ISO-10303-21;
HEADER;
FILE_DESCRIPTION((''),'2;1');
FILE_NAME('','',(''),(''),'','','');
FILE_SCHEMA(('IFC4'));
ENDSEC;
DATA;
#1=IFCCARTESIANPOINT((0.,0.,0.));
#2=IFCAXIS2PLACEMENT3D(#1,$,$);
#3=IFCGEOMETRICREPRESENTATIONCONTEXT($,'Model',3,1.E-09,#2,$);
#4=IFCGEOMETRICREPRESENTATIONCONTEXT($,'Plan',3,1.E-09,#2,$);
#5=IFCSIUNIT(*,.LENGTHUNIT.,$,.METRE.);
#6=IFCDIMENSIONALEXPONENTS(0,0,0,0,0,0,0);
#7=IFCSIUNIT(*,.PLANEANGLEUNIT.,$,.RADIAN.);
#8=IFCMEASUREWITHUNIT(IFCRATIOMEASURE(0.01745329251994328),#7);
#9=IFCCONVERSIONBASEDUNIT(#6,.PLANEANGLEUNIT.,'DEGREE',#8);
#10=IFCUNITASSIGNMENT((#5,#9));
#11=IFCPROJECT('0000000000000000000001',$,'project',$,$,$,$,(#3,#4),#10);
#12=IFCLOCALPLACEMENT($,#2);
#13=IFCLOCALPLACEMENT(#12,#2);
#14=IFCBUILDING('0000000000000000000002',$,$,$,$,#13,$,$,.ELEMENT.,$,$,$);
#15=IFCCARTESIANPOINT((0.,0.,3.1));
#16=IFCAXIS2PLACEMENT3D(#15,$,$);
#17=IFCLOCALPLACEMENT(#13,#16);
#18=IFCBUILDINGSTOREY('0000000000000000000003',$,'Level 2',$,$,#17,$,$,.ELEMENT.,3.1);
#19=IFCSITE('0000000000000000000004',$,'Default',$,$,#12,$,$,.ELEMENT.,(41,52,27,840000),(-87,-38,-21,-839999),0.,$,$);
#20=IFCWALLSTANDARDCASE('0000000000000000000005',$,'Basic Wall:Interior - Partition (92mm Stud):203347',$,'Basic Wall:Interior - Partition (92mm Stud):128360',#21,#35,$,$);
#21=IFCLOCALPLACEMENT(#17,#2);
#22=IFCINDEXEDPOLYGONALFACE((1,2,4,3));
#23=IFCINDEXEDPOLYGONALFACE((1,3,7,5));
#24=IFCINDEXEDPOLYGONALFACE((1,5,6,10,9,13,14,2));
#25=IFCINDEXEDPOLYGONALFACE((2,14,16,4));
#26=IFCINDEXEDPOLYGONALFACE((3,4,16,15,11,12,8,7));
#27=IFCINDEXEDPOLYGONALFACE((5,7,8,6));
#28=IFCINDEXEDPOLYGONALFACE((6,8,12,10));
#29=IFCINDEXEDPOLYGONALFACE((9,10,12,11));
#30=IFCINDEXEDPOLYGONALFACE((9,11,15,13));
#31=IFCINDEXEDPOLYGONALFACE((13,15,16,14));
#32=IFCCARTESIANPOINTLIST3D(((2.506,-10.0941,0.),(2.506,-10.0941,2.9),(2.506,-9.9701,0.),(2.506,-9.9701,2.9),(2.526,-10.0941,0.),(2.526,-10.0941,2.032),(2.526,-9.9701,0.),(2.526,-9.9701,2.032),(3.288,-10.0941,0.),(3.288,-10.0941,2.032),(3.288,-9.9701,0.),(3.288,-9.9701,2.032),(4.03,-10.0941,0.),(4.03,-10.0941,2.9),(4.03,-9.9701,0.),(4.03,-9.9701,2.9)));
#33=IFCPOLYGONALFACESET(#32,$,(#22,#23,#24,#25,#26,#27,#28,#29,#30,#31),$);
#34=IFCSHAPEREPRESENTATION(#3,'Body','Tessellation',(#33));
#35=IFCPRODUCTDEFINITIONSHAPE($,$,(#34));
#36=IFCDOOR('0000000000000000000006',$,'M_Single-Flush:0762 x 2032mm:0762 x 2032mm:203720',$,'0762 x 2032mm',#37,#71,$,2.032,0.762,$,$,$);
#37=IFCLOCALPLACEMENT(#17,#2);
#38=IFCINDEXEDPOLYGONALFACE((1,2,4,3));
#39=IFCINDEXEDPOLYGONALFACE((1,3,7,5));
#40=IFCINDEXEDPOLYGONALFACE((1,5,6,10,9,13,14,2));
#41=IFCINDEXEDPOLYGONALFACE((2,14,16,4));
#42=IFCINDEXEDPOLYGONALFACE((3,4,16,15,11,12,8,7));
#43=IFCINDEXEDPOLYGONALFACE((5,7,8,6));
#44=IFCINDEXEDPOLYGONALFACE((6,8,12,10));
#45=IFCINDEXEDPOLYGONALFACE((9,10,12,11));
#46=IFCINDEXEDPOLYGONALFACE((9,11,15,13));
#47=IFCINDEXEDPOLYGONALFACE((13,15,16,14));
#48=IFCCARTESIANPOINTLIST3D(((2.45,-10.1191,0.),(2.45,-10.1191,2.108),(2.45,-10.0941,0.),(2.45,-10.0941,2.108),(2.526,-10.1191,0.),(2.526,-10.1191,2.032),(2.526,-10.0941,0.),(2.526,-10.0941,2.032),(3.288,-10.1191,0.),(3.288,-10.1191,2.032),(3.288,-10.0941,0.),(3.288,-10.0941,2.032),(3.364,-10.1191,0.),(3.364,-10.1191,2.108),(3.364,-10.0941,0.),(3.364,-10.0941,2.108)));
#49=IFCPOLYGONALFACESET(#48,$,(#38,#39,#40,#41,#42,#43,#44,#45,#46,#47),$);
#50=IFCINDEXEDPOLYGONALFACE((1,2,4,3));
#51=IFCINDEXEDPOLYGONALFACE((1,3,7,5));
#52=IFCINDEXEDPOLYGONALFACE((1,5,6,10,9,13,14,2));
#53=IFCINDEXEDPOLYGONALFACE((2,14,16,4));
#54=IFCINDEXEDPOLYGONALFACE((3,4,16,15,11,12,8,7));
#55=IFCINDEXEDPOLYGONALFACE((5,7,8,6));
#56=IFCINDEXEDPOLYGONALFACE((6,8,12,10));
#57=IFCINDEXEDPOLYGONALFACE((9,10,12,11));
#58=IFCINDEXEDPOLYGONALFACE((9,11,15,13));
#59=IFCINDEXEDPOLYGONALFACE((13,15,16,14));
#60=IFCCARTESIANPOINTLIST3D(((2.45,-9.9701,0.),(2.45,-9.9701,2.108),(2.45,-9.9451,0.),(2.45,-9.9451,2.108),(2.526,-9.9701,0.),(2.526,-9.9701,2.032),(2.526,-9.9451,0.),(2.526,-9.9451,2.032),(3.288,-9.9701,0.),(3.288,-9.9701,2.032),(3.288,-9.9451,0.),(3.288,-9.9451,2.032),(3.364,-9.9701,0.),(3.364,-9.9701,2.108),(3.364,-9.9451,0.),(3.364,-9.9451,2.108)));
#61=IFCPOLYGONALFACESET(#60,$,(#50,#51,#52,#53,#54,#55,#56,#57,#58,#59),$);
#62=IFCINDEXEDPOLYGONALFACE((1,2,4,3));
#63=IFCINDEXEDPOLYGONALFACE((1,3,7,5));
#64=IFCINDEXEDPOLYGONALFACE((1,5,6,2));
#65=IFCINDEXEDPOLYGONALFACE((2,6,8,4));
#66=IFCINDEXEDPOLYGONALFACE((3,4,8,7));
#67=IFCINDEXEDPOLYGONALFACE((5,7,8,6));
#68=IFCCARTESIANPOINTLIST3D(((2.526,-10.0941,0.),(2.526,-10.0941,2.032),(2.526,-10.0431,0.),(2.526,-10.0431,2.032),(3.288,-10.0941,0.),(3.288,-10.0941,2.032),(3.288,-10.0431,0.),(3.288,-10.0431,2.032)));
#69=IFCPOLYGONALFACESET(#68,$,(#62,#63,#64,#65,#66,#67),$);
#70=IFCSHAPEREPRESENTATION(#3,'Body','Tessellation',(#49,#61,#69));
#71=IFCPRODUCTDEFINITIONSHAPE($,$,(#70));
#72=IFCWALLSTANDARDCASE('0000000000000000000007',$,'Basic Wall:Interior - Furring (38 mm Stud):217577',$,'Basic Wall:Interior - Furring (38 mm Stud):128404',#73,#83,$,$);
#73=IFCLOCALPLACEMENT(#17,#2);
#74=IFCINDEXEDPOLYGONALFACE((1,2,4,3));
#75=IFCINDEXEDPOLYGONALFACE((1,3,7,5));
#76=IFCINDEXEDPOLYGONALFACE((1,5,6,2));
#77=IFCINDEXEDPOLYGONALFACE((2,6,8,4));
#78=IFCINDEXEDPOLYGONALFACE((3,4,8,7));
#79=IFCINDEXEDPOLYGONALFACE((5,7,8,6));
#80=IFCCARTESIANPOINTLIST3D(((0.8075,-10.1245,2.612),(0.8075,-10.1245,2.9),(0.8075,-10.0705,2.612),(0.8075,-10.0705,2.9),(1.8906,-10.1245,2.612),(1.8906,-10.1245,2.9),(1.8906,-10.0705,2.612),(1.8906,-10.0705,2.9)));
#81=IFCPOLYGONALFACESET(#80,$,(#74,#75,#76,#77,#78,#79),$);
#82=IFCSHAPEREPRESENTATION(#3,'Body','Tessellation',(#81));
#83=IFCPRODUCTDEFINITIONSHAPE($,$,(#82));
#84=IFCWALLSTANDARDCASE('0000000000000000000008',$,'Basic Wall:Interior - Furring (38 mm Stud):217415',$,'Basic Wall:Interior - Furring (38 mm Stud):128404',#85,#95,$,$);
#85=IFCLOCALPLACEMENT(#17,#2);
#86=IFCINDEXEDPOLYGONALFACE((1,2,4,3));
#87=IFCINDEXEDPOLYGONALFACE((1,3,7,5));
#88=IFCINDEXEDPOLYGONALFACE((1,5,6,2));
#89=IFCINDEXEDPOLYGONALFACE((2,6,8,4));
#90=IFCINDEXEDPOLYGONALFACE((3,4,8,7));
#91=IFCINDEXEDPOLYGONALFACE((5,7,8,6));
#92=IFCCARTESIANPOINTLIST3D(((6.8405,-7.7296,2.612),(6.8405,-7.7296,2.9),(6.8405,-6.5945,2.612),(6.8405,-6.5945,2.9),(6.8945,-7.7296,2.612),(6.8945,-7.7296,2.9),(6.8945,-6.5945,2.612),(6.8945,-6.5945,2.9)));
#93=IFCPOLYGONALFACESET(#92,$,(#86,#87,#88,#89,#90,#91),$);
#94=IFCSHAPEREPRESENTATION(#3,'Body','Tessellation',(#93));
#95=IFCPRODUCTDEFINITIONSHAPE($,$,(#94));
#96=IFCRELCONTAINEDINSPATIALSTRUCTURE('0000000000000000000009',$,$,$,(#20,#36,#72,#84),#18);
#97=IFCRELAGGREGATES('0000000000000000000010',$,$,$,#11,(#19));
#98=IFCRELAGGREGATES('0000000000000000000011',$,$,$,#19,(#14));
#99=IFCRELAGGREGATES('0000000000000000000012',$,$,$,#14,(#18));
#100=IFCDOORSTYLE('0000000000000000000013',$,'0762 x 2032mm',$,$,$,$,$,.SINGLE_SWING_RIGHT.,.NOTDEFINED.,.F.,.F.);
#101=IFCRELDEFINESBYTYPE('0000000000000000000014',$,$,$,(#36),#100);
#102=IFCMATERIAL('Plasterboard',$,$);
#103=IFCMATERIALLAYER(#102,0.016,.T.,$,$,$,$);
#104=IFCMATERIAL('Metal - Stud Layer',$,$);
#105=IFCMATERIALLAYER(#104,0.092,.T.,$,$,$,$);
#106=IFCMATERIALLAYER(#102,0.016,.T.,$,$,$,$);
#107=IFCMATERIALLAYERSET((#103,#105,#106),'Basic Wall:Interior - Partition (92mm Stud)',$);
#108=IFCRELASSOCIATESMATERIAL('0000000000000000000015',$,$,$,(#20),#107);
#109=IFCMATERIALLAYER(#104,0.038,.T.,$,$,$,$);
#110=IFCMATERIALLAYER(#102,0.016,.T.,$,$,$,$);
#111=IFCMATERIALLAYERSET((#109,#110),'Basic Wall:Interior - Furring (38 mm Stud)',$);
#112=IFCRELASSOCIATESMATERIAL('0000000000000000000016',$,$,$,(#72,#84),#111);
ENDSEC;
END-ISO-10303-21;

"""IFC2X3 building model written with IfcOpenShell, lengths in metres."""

from ifc_helpers import new_model, entity, si_unit, converted_unit, frame, frame_2d, origin, origin_2d_with_axis, place, context, project, spatial, polyline, rectangle, outline, extrude, source, transform, mapped, material, layer, layer_set, layer_usage, type_object, type_shapes, element, fill, save


model = new_model("IFC2X3")

# Units and contexts
model_context = context("Model", 3, precision=1e-09, world=origin())
plan_context = context("Plan", 3, precision=1e-09, world=origin())
ifc_project = project(units=[si_unit("LENGTHUNIT", "METRE"), converted_unit("PLANEANGLEUNIT", "DEGREE", entity("IfcRatioMeasure", 0.01745329251994328), si_unit("PLANEANGLEUNIT", "RADIAN"), dimensions=[0, 0, 0, 0, 0, 0, 0])], contexts=[model_context, plan_context])

# Site, building, storey
site_placement = place(None, origin())
site = spatial("IfcSite", under=ifc_project, at=site_placement, Name="Default", CompositionType="ELEMENT", RefLatitude=(41, 52, 27, 840000), RefLongitude=(-87, -38, -21, -839999), RefElevation=0.0)
building_placement = place(site_placement, origin())
building = spatial("IfcBuilding", under=site, at=building_placement, CompositionType="ELEMENT")
storey_placement = place(building_placement, frame((0.0, 0.0, 3.1)))
storey = spatial("IfcBuildingStorey", under=building, at=storey_placement, Name="Level 2", CompositionType="ELEMENT", Elevation=3.1)

# Shared definitions
ifc_material_1 = material(Name="Plasterboard")
ifc_layer_1 = layer(ifc_material_1, 0.016, ventilated=True)
ifc_material_2 = material(Name="Metal - Stud Layer")
ifc_layer_2 = layer(ifc_material_2, 0.092, ventilated=True)
ifc_layer_3 = layer(ifc_material_1, 0.016, ventilated=True)
ifc_layer_set_1 = layer_set([ifc_layer_1, ifc_layer_2, ifc_layer_3], Name="Basic Wall:Interior - Partition (92mm Stud)")
ifc_layer_usage_1 = layer_usage(ifc_layer_set_1, "AXIS2", "NEGATIVE", 0.062)
ifc_layer_4 = layer(ifc_material_2, 0.038, ventilated=True)
ifc_layer_5 = layer(ifc_material_1, 0.016, ventilated=True)
ifc_layer_set_2 = layer_set([ifc_layer_4, ifc_layer_5], Name="Basic Wall:Interior - Furring (38 mm Stud)")
ifc_layer_usage_2 = layer_usage(ifc_layer_set_2, "AXIS2", "NEGATIVE", 0.027)

# Shared definitions
door_style = type_object("IfcDoorStyle", Name="0762 x 2032mm", ConstructionType="NOTDEFINED", OperationType="SINGLE_SWING_RIGHT", ParameterTakesPrecedence=False, Sizeable=False)
shared_shape = source(origin(), model_context, "Body", "SweptSolid", [
    extrude(outline(polyline([(-0.457, -1.073), (0.457, -1.073), (0.457, 1.035), (0.381, 1.035), (0.381, -0.997), (-0.381, -0.997), (-0.381, 1.035), (-0.457, 1.035), (-0.457, -1.073)])), frame((0.381, 0.124, 1.035), z_axis=(0.0, 1.0, 0.0), x_axis=(1.0, 0.0, 0.0)), (0.0, 0.0, 1.0), 0.025),
    extrude(outline(polyline([(-1.073, -0.457), (1.035, -0.457), (1.035, -0.381), (-0.997, -0.381), (-0.997, 0.381), (1.035, 0.381), (1.035, 0.457), (-1.073, 0.457), (-1.073, -0.457)])), frame((0.381, -0.025, 1.035), z_axis=(0.0, 1.0, 0.0), x_axis=(0.0, 0.0, -1.0)), (0.0, 0.0, 1.0), 0.025),
    extrude(rectangle(XDim=0.051, YDim=0.762, at=origin_2d_with_axis()), frame((0.381, 0.0985, 0.0), z_axis=(0.0, 0.0, 1.0), x_axis=(0.0, 1.0, 0.0)), (0.0, 0.0, 1.0), 2.032),
])
type_shapes(door_style, [shared_shape])

# Wall, opening, door
wall_1_placement = place(storey_placement, frame((4.03, -10.0321, 0.0), z_axis=(0.0, 0.0, 1.0), x_axis=(-1.0, 0.0, 0.0)))
wall_1 = element("IfcWallStandardCase", 1, at=wall_1_placement, inside=storey, material=ifc_layer_usage_1, Name="Basic Wall:Interior - Partition (92mm Stud):203347", ObjectType="Basic Wall:Interior - Partition (92mm Stud):128360", context=model_context, shape_type="SweptSolid", body=[
    extrude(rectangle(XDim=1.524, YDim=0.124, at=frame_2d((0.762, 0.0), x_axis=(-1.0, 0.0))), origin(), (0.0, 0.0, 1.0), 2.9),
])
opening_1_placement = place(wall_1_placement, frame((0.742, -0.062, 0.0)))
opening_1 = element("IfcOpeningElement", 2, at=opening_1_placement, cuts=wall_1, ObjectType="Opening", context=model_context, shape_type="SweptSolid", body=[
    extrude(rectangle(XDim=0.762, YDim=2.032, at=frame_2d((1.016, 0.381), x_axis=(0.0, 1.0))), frame((0.0, 0.0, 0.0), z_axis=(0.0, 1.0, 0.0), x_axis=(0.0, 0.0, 1.0)), (0.0, 0.0, 1.0), 0.124),
])
door_1_placement = place(opening_1_placement, origin())
door_1 = element("IfcDoor", 3, at=door_1_placement, inside=storey, type_object=door_style, Name="M_Single-Flush:0762 x 2032mm:0762 x 2032mm:203720", ObjectType="0762 x 2032mm", OverallHeight=2.032, OverallWidth=0.762, context=model_context, shape_type="MappedRepresentation", body=[
    mapped(shared_shape, transform((0.0, 0.0, 0.0), scale=1.0)),
])
fill(opening_1, door_1)

# Walls
wall_2_placement = place(storey_placement, frame((0.8075, -10.0975, 2.612)))
element("IfcWallStandardCase", 4, at=wall_2_placement, inside=storey, material=ifc_layer_usage_2, Name="Basic Wall:Interior - Furring (38 mm Stud):217577", ObjectType="Basic Wall:Interior - Furring (38 mm Stud):128404", context=model_context, shape_type="SweptSolid", body=[
    extrude(rectangle(XDim=1.0831, YDim=0.054, at=frame_2d((0.5415, 0.0), x_axis=(-1.0, 0.0))), origin(), (0.0, 0.0, 1.0), 0.288),
])
wall_3_placement = place(storey_placement, frame((6.8675, -7.7296, 2.612), z_axis=(0.0, 0.0, 1.0), x_axis=(0.0, 1.0, 0.0)))
element("IfcWallStandardCase", 5, at=wall_3_placement, inside=storey, material=ifc_layer_usage_2, Name="Basic Wall:Interior - Furring (38 mm Stud):217415", ObjectType="Basic Wall:Interior - Furring (38 mm Stud):128404", context=model_context, shape_type="SweptSolid", body=[
    extrude(rectangle(XDim=1.1351, YDim=0.054, at=frame_2d((0.5675, 0.0), x_axis=(-1.0, 0.0))), origin(), (0.0, 0.0, 1.0), 0.288),
])

save(model, "model.ifc")
